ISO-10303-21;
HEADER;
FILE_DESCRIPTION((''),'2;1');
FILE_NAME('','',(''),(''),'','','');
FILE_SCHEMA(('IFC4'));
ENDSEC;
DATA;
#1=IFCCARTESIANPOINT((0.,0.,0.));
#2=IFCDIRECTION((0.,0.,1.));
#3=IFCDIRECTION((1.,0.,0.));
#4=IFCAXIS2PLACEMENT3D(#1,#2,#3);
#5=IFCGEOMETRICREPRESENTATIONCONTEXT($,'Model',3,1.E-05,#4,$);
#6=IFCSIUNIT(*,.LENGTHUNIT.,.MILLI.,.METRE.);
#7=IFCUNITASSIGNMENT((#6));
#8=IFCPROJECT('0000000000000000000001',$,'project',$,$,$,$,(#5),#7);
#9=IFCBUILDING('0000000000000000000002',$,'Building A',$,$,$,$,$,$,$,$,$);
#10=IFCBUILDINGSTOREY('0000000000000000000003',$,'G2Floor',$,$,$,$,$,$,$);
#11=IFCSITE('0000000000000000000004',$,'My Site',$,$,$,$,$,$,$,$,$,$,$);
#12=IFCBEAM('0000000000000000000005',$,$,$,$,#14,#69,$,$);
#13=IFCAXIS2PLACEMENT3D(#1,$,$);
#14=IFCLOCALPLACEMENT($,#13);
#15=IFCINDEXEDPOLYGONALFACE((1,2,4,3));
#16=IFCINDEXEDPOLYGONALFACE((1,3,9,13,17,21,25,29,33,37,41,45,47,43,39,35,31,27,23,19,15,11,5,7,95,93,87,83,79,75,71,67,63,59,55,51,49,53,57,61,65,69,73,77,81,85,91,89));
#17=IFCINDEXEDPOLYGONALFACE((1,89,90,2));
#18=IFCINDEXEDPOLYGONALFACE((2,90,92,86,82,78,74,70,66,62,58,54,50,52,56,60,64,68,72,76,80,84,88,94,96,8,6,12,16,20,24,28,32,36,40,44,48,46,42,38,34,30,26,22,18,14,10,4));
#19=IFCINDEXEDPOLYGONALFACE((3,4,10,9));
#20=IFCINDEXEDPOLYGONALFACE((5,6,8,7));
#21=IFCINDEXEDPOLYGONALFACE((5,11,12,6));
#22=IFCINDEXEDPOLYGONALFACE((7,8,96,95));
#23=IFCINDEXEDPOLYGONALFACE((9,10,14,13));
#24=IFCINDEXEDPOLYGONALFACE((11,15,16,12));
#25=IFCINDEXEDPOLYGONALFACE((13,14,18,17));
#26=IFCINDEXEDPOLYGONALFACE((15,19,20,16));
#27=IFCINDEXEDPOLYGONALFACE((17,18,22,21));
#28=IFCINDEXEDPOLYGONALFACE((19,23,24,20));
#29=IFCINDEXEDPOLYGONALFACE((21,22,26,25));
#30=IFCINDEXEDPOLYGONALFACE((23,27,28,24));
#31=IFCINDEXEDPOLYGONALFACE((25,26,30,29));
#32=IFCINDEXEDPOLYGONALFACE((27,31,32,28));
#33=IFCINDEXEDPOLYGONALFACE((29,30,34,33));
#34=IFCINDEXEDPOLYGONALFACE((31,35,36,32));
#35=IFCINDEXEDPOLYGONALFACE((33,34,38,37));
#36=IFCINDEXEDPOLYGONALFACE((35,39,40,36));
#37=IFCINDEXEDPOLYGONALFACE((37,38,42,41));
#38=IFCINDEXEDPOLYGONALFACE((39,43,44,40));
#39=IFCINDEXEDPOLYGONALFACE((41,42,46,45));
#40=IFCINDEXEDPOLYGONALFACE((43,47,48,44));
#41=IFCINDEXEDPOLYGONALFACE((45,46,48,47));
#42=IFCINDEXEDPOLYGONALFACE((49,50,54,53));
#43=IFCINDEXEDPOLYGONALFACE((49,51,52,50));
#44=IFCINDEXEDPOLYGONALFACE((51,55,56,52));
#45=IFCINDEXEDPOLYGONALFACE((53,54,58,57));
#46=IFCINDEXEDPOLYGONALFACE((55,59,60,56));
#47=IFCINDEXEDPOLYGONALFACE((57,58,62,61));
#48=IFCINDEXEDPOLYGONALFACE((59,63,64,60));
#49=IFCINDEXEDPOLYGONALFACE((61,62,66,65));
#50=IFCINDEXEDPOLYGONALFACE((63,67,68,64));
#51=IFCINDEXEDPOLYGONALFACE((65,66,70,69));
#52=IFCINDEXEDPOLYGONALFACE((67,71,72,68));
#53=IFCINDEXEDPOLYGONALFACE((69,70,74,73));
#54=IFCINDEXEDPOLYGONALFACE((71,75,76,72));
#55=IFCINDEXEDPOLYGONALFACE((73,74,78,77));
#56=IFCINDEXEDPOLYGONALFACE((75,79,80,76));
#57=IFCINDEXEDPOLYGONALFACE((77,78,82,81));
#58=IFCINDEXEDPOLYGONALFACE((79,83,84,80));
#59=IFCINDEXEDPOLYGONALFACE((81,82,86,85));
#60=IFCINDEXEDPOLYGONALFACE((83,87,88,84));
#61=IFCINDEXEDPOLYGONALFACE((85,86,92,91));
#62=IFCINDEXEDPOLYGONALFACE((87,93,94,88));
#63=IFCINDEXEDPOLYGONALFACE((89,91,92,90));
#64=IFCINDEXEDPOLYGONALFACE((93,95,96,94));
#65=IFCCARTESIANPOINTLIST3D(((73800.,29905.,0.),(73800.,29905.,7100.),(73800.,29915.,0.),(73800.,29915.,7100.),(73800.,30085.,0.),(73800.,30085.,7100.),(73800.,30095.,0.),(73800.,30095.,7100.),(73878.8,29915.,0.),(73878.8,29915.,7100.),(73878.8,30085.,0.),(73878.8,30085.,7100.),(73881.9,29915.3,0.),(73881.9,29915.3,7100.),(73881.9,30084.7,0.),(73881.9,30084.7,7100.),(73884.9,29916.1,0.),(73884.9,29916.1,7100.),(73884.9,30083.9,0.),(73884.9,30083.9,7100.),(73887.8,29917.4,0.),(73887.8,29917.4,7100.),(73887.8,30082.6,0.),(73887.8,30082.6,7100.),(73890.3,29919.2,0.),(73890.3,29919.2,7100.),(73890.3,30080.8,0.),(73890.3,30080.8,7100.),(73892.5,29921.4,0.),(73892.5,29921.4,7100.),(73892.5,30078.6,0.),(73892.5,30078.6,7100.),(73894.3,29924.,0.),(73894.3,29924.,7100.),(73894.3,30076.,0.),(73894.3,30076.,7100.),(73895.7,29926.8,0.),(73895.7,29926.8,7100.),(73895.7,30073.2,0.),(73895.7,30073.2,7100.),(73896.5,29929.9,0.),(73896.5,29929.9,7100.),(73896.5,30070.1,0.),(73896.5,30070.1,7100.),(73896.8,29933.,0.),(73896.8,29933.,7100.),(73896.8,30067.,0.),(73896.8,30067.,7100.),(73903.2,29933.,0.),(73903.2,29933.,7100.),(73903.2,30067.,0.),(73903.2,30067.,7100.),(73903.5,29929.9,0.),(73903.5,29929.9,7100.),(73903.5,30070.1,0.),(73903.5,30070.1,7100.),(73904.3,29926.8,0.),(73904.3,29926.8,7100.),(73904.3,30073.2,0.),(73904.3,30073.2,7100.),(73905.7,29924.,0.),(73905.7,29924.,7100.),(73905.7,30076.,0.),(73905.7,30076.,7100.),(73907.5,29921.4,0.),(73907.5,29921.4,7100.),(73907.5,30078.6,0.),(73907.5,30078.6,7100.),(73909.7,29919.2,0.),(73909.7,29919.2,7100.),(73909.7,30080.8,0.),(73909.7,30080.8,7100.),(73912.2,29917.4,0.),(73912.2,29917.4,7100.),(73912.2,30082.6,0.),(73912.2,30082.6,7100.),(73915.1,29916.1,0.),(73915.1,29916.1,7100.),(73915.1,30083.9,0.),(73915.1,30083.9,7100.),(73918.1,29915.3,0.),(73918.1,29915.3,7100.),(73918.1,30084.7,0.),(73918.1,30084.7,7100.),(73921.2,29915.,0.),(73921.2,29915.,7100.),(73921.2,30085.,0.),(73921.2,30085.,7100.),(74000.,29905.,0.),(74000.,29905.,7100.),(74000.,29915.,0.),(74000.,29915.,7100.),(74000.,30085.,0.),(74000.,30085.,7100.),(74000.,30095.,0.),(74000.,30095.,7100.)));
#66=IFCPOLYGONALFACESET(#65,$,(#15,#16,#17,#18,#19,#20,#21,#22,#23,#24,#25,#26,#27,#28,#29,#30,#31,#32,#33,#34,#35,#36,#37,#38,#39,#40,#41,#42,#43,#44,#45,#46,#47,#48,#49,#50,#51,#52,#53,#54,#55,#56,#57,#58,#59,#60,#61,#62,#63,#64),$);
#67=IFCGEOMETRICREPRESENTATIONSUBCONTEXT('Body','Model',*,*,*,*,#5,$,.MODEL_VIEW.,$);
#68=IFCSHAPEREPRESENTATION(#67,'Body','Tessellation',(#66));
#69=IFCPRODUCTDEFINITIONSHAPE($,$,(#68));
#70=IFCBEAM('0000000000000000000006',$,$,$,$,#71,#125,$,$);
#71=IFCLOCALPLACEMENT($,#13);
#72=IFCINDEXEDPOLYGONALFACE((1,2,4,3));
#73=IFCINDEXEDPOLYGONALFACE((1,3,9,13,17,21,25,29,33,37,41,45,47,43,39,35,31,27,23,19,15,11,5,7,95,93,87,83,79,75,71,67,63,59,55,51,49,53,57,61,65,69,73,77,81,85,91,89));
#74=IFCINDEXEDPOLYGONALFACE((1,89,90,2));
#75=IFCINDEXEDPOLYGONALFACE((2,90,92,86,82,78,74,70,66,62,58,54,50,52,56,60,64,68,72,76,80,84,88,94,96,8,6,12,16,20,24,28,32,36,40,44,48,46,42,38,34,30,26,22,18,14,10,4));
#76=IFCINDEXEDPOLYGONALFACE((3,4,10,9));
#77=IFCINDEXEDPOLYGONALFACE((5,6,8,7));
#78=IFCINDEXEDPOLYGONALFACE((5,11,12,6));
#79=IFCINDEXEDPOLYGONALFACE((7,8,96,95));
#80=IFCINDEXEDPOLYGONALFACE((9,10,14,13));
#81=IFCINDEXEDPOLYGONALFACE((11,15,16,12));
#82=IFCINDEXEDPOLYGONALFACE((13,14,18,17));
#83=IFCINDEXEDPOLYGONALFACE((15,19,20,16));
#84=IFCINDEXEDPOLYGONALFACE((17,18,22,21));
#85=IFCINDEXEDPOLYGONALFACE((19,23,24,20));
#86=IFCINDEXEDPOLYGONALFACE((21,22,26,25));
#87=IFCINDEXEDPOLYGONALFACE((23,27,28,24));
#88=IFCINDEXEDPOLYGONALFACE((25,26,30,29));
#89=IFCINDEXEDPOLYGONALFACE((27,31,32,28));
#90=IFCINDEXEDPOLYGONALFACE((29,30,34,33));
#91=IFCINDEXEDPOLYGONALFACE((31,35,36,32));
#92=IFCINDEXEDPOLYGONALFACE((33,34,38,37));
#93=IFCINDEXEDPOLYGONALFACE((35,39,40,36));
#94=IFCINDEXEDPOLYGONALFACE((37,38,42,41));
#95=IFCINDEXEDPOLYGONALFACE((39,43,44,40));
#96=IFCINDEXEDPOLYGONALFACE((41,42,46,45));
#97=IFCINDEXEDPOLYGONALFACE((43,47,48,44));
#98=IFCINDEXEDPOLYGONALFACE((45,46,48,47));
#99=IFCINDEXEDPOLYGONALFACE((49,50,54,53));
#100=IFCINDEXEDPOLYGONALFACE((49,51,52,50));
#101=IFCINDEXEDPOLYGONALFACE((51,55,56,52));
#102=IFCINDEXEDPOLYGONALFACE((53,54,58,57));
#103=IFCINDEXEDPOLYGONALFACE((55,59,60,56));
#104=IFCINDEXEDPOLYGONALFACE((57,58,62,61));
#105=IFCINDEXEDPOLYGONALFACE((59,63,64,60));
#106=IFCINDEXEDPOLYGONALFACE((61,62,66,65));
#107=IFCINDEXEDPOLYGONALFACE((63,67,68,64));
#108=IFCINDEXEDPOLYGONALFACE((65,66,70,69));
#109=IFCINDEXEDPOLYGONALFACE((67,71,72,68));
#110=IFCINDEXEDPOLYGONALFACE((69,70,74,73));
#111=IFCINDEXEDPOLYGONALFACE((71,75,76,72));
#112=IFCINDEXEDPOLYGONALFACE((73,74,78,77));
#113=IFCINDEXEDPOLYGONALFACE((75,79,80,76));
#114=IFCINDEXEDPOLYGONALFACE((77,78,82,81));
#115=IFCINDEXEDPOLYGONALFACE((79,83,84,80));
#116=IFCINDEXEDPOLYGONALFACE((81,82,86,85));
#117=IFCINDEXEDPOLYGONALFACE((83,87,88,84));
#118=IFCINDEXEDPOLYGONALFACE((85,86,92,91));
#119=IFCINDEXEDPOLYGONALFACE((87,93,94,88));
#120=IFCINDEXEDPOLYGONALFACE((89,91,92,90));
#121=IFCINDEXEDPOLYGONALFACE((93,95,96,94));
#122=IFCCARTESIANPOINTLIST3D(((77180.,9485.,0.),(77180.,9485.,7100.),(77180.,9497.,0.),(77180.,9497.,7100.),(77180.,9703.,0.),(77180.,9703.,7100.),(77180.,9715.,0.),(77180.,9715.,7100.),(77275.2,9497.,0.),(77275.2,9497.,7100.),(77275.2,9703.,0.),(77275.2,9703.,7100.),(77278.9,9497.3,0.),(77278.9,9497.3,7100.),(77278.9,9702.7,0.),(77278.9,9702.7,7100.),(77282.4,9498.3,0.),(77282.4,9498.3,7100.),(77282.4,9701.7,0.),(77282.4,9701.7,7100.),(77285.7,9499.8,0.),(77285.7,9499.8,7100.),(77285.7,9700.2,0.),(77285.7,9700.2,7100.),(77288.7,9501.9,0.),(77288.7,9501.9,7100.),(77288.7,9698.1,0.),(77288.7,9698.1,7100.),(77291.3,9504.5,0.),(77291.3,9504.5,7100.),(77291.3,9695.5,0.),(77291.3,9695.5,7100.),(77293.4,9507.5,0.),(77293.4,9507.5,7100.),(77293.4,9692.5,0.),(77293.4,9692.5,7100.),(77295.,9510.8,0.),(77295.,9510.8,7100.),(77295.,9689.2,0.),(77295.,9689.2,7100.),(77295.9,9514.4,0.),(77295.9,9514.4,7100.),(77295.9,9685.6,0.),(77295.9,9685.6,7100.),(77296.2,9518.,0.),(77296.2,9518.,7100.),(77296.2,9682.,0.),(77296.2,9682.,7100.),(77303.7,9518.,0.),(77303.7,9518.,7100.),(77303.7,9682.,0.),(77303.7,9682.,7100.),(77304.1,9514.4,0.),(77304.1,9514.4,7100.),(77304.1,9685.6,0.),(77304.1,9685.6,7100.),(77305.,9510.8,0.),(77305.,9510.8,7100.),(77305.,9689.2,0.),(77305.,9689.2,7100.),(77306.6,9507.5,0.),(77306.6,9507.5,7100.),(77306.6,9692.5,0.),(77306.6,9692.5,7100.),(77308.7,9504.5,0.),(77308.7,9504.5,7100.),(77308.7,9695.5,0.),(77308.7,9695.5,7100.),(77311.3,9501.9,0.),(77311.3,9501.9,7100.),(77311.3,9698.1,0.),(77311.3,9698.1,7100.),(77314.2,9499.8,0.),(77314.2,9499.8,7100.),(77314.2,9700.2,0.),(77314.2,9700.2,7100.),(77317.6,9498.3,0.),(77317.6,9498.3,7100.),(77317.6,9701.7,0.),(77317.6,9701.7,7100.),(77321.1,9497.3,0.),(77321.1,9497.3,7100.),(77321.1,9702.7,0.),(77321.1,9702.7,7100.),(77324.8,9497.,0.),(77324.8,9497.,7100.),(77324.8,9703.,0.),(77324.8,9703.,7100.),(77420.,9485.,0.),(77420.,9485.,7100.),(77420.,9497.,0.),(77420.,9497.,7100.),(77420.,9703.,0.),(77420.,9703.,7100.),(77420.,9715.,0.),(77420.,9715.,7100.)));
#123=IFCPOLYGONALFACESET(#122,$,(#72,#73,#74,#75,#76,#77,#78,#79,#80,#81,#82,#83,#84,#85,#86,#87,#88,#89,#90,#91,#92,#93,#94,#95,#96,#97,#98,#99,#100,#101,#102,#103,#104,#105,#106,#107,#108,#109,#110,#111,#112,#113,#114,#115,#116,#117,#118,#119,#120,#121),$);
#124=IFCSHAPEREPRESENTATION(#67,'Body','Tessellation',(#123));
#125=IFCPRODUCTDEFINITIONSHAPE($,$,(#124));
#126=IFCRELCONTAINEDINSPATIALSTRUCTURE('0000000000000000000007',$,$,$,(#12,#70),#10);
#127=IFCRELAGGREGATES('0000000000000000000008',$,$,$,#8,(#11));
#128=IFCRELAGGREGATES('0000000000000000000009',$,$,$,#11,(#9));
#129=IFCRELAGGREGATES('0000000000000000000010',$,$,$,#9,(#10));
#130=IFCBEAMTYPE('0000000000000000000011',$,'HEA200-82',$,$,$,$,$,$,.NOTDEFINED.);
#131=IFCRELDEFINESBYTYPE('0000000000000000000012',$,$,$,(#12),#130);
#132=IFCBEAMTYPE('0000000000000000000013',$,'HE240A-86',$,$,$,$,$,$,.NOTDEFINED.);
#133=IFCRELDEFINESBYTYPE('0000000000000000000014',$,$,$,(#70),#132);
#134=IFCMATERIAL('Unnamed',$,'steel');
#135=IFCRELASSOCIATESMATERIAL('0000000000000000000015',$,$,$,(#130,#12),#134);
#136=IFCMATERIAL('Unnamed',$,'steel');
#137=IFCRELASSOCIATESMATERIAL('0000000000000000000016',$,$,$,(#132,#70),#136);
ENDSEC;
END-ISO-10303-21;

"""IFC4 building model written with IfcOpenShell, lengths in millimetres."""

from ifc_helpers import new_model, si_unit, frame, origin_with_axes, place, context, subcontext, project, spatial, polyline, outline, extrude, material, material_profile, profile_set, profile_usage, type_object, element, save


model = new_model("IFC4")

# Units and contexts
model_context = context("Model", 3, precision=1e-05, world=origin_with_axes())
body_context = subcontext(model_context, "Body", "Model", "MODEL_VIEW")
ifc_project = project(units=[si_unit("LENGTHUNIT", "METRE", prefix="MILLI")], contexts=[model_context])

# Site, building, storey
site = spatial("IfcSite", under=ifc_project, Name="My Site")
building = spatial("IfcBuilding", under=site, Name="Building A")
storey = spatial("IfcBuildingStorey", under=building, Name="G2Floor")

# Beams
ifc_material_1 = material(Name="Unnamed", Category="steel")
ifc_material_profile_1 = material_profile(ifc_material_1, outline(polyline([(100.0, -95.0), (100.0, -85.0), (100.0, -85.0), (21.2, -85.0), (21.2, -85.0), (18.1, -84.7), (18.1, -84.7), (15.1, -83.9), (15.1, -83.9), (12.2, -82.6), (12.2, -82.6), (9.7, -80.8), (9.7, -80.8), (7.5, -78.6), (7.5, -78.6), (5.7, -76.0), (5.7, -76.0), (4.3, -73.2), (4.3, -73.2), (3.5, -70.1), (3.5, -70.1), (3.2, -67.0), (3.2, -67.0), (3.2, 67.0), (3.2, 67.0), (3.5, 70.1), (3.5, 70.1), (4.3, 73.2), (4.3, 73.2), (5.7, 76.0), (5.7, 76.0), (7.5, 78.6), (7.5, 78.6), (9.7, 80.8), (9.7, 80.8), (12.2, 82.6), (12.2, 82.6), (15.1, 83.9), (15.1, 83.9), (18.1, 84.7), (18.1, 84.7), (21.2, 85.0), (21.2, 85.0), (100.0, 85.0), (100.0, 85.0), (100.0, 95.0), (100.0, 95.0), (-100.0, 95.0), (-100.0, 95.0), (-100.0, 85.0), (-100.0, 85.0), (-21.2, 85.0), (-21.2, 85.0), (-18.1, 84.7), (-18.1, 84.7), (-15.1, 83.9), (-15.1, 83.9), (-12.2, 82.6), (-12.2, 82.6), (-9.7, 80.8), (-9.7, 80.8), (-7.5, 78.6), (-7.5, 78.6), (-5.7, 76.0), (-5.7, 76.0), (-4.3, 73.2), (-4.3, 73.2), (-3.5, 70.1), (-3.5, 70.1), (-3.2, 67.0), (-3.2, 67.0), (-3.2, -67.0), (-3.2, -67.0), (-3.5, -70.1), (-3.5, -70.1), (-4.3, -73.2), (-4.3, -73.2), (-5.7, -76.0), (-5.7, -76.0), (-7.5, -78.6), (-7.5, -78.6), (-9.7, -80.8), (-9.7, -80.8), (-12.2, -82.6), (-12.2, -82.6), (-15.1, -83.9), (-15.1, -83.9), (-18.1, -84.7), (-18.1, -84.7), (-21.2, -85.0), (-21.2, -85.0), (-100.0, -85.0), (-100.0, -85.0), (-100.0, -95.0), (-100.0, -95.0), (100.0, -95.0)])))
ifc_profile_set_1 = profile_set([ifc_material_profile_1], Name="HEA200-82")
ifc_profile_usage_1 = profile_usage(ifc_profile_set_1)
beam_type_1 = type_object("IfcBeamType", Name="HEA200-82", PredefinedType="NOTDEFINED", material=ifc_profile_set_1)
beam_1_placement = place(None, frame((73900.0, 30000.0, 0.0), z_axis=(0.0, 0.0, 1.0), x_axis=(1.0, 0.0, 0.0)))
element("IfcBeam", 1, at=beam_1_placement, inside=storey, type_object=beam_type_1, material=ifc_profile_usage_1, context=body_context, shape_type="SweptSolid", body=[
    extrude(outline(polyline([(100.0, -95.0), (100.0, -85.0), (100.0, -85.0), (21.2, -85.0), (21.2, -85.0), (18.1, -84.7), (18.1, -84.7), (15.1, -83.9), (15.1, -83.9), (12.2, -82.6), (12.2, -82.6), (9.7, -80.8), (9.7, -80.8), (7.5, -78.6), (7.5, -78.6), (5.7, -76.0), (5.7, -76.0), (4.3, -73.2), (4.3, -73.2), (3.5, -70.1), (3.5, -70.1), (3.2, -67.0), (3.2, -67.0), (3.2, 67.0), (3.2, 67.0), (3.5, 70.1), (3.5, 70.1), (4.3, 73.2), (4.3, 73.2), (5.7, 76.0), (5.7, 76.0), (7.5, 78.6), (7.5, 78.6), (9.7, 80.8), (9.7, 80.8), (12.2, 82.6), (12.2, 82.6), (15.1, 83.9), (15.1, 83.9), (18.1, 84.7), (18.1, 84.7), (21.2, 85.0), (21.2, 85.0), (100.0, 85.0), (100.0, 85.0), (100.0, 95.0), (100.0, 95.0), (-100.0, 95.0), (-100.0, 95.0), (-100.0, 85.0), (-100.0, 85.0), (-21.2, 85.0), (-21.2, 85.0), (-18.1, 84.7), (-18.1, 84.7), (-15.1, 83.9), (-15.1, 83.9), (-12.2, 82.6), (-12.2, 82.6), (-9.7, 80.8), (-9.7, 80.8), (-7.5, 78.6), (-7.5, 78.6), (-5.7, 76.0), (-5.7, 76.0), (-4.3, 73.2), (-4.3, 73.2), (-3.5, 70.1), (-3.5, 70.1), (-3.2, 67.0), (-3.2, 67.0), (-3.2, -67.0), (-3.2, -67.0), (-3.5, -70.1), (-3.5, -70.1), (-4.3, -73.2), (-4.3, -73.2), (-5.7, -76.0), (-5.7, -76.0), (-7.5, -78.6), (-7.5, -78.6), (-9.7, -80.8), (-9.7, -80.8), (-12.2, -82.6), (-12.2, -82.6), (-15.1, -83.9), (-15.1, -83.9), (-18.1, -84.7), (-18.1, -84.7), (-21.2, -85.0), (-21.2, -85.0), (-100.0, -85.0), (-100.0, -85.0), (-100.0, -95.0), (-100.0, -95.0), (100.0, -95.0)])), origin_with_axes(), (0.0, 0.0, 1.0), 7100.0),
])
ifc_material_2 = material(Name="Unnamed", Category="steel")
ifc_material_profile_2 = material_profile(ifc_material_2, outline(polyline([(120.0, -115.0), (120.0, -103.0), (120.0, -103.0), (24.8, -103.0), (24.8, -103.0), (21.1, -102.7), (21.1, -102.7), (17.6, -101.7), (17.6, -101.7), (14.2, -100.2), (14.2, -100.2), (11.3, -98.1), (11.3, -98.1), (8.7, -95.5), (8.7, -95.5), (6.6, -92.5), (6.6, -92.5), (5.0, -89.2), (5.0, -89.2), (4.1, -85.6), (4.1, -85.6), (3.8, -82.0), (3.8, -82.0), (3.8, 82.0), (3.8, 82.0), (4.1, 85.6), (4.1, 85.6), (5.0, 89.2), (5.0, 89.2), (6.6, 92.5), (6.6, 92.5), (8.7, 95.5), (8.7, 95.5), (11.3, 98.1), (11.3, 98.1), (14.2, 100.2), (14.2, 100.2), (17.6, 101.7), (17.6, 101.7), (21.1, 102.7), (21.1, 102.7), (24.8, 103.0), (24.8, 103.0), (120.0, 103.0), (120.0, 103.0), (120.0, 115.0), (120.0, 115.0), (-120.0, 115.0), (-120.0, 115.0), (-120.0, 103.0), (-120.0, 103.0), (-24.8, 103.0), (-24.8, 103.0), (-21.1, 102.7), (-21.1, 102.7), (-17.6, 101.7), (-17.6, 101.7), (-14.2, 100.2), (-14.2, 100.2), (-11.3, 98.1), (-11.3, 98.1), (-8.7, 95.5), (-8.7, 95.5), (-6.6, 92.5), (-6.6, 92.5), (-5.0, 89.2), (-5.0, 89.2), (-4.1, 85.6), (-4.1, 85.6), (-3.8, 82.0), (-3.8, 82.0), (-3.8, -82.0), (-3.8, -82.0), (-4.1, -85.6), (-4.1, -85.6), (-5.0, -89.2), (-5.0, -89.2), (-6.6, -92.5), (-6.6, -92.5), (-8.7, -95.5), (-8.7, -95.5), (-11.3, -98.1), (-11.3, -98.1), (-14.2, -100.2), (-14.2, -100.2), (-17.6, -101.7), (-17.6, -101.7), (-21.1, -102.7), (-21.1, -102.7), (-24.8, -103.0), (-24.8, -103.0), (-120.0, -103.0), (-120.0, -103.0), (-120.0, -115.0), (-120.0, -115.0), (120.0, -115.0)])))
ifc_profile_set_2 = profile_set([ifc_material_profile_2], Name="HE240A-86")
ifc_profile_usage_2 = profile_usage(ifc_profile_set_2)
beam_type_2 = type_object("IfcBeamType", Name="HE240A-86", PredefinedType="NOTDEFINED", material=ifc_profile_set_2)
beam_2_placement = place(None, frame((77300.0, 9600.0, 0.0), z_axis=(0.0, 0.0, 1.0), x_axis=(1.0, 0.0, 0.0)))
element("IfcBeam", 2, at=beam_2_placement, inside=storey, type_object=beam_type_2, material=ifc_profile_usage_2, context=body_context, shape_type="SweptSolid", body=[
    extrude(outline(polyline([(120.0, -115.0), (120.0, -103.0), (120.0, -103.0), (24.8, -103.0), (24.8, -103.0), (21.1, -102.7), (21.1, -102.7), (17.6, -101.7), (17.6, -101.7), (14.2, -100.2), (14.2, -100.2), (11.3, -98.1), (11.3, -98.1), (8.7, -95.5), (8.7, -95.5), (6.6, -92.5), (6.6, -92.5), (5.0, -89.2), (5.0, -89.2), (4.1, -85.6), (4.1, -85.6), (3.8, -82.0), (3.8, -82.0), (3.8, 82.0), (3.8, 82.0), (4.1, 85.6), (4.1, 85.6), (5.0, 89.2), (5.0, 89.2), (6.6, 92.5), (6.6, 92.5), (8.7, 95.5), (8.7, 95.5), (11.3, 98.1), (11.3, 98.1), (14.2, 100.2), (14.2, 100.2), (17.6, 101.7), (17.6, 101.7), (21.1, 102.7), (21.1, 102.7), (24.8, 103.0), (24.8, 103.0), (120.0, 103.0), (120.0, 103.0), (120.0, 115.0), (120.0, 115.0), (-120.0, 115.0), (-120.0, 115.0), (-120.0, 103.0), (-120.0, 103.0), (-24.8, 103.0), (-24.8, 103.0), (-21.1, 102.7), (-21.1, 102.7), (-17.6, 101.7), (-17.6, 101.7), (-14.2, 100.2), (-14.2, 100.2), (-11.3, 98.1), (-11.3, 98.1), (-8.7, 95.5), (-8.7, 95.5), (-6.6, 92.5), (-6.6, 92.5), (-5.0, 89.2), (-5.0, 89.2), (-4.1, 85.6), (-4.1, 85.6), (-3.8, 82.0), (-3.8, 82.0), (-3.8, -82.0), (-3.8, -82.0), (-4.1, -85.6), (-4.1, -85.6), (-5.0, -89.2), (-5.0, -89.2), (-6.6, -92.5), (-6.6, -92.5), (-8.7, -95.5), (-8.7, -95.5), (-11.3, -98.1), (-11.3, -98.1), (-14.2, -100.2), (-14.2, -100.2), (-17.6, -101.7), (-17.6, -101.7), (-21.1, -102.7), (-21.1, -102.7), (-24.8, -103.0), (-24.8, -103.0), (-120.0, -103.0), (-120.0, -103.0), (-120.0, -115.0), (-120.0, -115.0), (120.0, -115.0)])), origin_with_axes(), (0.0, 0.0, 1.0), 7100.0),
])

save(model, "model.ifc")
